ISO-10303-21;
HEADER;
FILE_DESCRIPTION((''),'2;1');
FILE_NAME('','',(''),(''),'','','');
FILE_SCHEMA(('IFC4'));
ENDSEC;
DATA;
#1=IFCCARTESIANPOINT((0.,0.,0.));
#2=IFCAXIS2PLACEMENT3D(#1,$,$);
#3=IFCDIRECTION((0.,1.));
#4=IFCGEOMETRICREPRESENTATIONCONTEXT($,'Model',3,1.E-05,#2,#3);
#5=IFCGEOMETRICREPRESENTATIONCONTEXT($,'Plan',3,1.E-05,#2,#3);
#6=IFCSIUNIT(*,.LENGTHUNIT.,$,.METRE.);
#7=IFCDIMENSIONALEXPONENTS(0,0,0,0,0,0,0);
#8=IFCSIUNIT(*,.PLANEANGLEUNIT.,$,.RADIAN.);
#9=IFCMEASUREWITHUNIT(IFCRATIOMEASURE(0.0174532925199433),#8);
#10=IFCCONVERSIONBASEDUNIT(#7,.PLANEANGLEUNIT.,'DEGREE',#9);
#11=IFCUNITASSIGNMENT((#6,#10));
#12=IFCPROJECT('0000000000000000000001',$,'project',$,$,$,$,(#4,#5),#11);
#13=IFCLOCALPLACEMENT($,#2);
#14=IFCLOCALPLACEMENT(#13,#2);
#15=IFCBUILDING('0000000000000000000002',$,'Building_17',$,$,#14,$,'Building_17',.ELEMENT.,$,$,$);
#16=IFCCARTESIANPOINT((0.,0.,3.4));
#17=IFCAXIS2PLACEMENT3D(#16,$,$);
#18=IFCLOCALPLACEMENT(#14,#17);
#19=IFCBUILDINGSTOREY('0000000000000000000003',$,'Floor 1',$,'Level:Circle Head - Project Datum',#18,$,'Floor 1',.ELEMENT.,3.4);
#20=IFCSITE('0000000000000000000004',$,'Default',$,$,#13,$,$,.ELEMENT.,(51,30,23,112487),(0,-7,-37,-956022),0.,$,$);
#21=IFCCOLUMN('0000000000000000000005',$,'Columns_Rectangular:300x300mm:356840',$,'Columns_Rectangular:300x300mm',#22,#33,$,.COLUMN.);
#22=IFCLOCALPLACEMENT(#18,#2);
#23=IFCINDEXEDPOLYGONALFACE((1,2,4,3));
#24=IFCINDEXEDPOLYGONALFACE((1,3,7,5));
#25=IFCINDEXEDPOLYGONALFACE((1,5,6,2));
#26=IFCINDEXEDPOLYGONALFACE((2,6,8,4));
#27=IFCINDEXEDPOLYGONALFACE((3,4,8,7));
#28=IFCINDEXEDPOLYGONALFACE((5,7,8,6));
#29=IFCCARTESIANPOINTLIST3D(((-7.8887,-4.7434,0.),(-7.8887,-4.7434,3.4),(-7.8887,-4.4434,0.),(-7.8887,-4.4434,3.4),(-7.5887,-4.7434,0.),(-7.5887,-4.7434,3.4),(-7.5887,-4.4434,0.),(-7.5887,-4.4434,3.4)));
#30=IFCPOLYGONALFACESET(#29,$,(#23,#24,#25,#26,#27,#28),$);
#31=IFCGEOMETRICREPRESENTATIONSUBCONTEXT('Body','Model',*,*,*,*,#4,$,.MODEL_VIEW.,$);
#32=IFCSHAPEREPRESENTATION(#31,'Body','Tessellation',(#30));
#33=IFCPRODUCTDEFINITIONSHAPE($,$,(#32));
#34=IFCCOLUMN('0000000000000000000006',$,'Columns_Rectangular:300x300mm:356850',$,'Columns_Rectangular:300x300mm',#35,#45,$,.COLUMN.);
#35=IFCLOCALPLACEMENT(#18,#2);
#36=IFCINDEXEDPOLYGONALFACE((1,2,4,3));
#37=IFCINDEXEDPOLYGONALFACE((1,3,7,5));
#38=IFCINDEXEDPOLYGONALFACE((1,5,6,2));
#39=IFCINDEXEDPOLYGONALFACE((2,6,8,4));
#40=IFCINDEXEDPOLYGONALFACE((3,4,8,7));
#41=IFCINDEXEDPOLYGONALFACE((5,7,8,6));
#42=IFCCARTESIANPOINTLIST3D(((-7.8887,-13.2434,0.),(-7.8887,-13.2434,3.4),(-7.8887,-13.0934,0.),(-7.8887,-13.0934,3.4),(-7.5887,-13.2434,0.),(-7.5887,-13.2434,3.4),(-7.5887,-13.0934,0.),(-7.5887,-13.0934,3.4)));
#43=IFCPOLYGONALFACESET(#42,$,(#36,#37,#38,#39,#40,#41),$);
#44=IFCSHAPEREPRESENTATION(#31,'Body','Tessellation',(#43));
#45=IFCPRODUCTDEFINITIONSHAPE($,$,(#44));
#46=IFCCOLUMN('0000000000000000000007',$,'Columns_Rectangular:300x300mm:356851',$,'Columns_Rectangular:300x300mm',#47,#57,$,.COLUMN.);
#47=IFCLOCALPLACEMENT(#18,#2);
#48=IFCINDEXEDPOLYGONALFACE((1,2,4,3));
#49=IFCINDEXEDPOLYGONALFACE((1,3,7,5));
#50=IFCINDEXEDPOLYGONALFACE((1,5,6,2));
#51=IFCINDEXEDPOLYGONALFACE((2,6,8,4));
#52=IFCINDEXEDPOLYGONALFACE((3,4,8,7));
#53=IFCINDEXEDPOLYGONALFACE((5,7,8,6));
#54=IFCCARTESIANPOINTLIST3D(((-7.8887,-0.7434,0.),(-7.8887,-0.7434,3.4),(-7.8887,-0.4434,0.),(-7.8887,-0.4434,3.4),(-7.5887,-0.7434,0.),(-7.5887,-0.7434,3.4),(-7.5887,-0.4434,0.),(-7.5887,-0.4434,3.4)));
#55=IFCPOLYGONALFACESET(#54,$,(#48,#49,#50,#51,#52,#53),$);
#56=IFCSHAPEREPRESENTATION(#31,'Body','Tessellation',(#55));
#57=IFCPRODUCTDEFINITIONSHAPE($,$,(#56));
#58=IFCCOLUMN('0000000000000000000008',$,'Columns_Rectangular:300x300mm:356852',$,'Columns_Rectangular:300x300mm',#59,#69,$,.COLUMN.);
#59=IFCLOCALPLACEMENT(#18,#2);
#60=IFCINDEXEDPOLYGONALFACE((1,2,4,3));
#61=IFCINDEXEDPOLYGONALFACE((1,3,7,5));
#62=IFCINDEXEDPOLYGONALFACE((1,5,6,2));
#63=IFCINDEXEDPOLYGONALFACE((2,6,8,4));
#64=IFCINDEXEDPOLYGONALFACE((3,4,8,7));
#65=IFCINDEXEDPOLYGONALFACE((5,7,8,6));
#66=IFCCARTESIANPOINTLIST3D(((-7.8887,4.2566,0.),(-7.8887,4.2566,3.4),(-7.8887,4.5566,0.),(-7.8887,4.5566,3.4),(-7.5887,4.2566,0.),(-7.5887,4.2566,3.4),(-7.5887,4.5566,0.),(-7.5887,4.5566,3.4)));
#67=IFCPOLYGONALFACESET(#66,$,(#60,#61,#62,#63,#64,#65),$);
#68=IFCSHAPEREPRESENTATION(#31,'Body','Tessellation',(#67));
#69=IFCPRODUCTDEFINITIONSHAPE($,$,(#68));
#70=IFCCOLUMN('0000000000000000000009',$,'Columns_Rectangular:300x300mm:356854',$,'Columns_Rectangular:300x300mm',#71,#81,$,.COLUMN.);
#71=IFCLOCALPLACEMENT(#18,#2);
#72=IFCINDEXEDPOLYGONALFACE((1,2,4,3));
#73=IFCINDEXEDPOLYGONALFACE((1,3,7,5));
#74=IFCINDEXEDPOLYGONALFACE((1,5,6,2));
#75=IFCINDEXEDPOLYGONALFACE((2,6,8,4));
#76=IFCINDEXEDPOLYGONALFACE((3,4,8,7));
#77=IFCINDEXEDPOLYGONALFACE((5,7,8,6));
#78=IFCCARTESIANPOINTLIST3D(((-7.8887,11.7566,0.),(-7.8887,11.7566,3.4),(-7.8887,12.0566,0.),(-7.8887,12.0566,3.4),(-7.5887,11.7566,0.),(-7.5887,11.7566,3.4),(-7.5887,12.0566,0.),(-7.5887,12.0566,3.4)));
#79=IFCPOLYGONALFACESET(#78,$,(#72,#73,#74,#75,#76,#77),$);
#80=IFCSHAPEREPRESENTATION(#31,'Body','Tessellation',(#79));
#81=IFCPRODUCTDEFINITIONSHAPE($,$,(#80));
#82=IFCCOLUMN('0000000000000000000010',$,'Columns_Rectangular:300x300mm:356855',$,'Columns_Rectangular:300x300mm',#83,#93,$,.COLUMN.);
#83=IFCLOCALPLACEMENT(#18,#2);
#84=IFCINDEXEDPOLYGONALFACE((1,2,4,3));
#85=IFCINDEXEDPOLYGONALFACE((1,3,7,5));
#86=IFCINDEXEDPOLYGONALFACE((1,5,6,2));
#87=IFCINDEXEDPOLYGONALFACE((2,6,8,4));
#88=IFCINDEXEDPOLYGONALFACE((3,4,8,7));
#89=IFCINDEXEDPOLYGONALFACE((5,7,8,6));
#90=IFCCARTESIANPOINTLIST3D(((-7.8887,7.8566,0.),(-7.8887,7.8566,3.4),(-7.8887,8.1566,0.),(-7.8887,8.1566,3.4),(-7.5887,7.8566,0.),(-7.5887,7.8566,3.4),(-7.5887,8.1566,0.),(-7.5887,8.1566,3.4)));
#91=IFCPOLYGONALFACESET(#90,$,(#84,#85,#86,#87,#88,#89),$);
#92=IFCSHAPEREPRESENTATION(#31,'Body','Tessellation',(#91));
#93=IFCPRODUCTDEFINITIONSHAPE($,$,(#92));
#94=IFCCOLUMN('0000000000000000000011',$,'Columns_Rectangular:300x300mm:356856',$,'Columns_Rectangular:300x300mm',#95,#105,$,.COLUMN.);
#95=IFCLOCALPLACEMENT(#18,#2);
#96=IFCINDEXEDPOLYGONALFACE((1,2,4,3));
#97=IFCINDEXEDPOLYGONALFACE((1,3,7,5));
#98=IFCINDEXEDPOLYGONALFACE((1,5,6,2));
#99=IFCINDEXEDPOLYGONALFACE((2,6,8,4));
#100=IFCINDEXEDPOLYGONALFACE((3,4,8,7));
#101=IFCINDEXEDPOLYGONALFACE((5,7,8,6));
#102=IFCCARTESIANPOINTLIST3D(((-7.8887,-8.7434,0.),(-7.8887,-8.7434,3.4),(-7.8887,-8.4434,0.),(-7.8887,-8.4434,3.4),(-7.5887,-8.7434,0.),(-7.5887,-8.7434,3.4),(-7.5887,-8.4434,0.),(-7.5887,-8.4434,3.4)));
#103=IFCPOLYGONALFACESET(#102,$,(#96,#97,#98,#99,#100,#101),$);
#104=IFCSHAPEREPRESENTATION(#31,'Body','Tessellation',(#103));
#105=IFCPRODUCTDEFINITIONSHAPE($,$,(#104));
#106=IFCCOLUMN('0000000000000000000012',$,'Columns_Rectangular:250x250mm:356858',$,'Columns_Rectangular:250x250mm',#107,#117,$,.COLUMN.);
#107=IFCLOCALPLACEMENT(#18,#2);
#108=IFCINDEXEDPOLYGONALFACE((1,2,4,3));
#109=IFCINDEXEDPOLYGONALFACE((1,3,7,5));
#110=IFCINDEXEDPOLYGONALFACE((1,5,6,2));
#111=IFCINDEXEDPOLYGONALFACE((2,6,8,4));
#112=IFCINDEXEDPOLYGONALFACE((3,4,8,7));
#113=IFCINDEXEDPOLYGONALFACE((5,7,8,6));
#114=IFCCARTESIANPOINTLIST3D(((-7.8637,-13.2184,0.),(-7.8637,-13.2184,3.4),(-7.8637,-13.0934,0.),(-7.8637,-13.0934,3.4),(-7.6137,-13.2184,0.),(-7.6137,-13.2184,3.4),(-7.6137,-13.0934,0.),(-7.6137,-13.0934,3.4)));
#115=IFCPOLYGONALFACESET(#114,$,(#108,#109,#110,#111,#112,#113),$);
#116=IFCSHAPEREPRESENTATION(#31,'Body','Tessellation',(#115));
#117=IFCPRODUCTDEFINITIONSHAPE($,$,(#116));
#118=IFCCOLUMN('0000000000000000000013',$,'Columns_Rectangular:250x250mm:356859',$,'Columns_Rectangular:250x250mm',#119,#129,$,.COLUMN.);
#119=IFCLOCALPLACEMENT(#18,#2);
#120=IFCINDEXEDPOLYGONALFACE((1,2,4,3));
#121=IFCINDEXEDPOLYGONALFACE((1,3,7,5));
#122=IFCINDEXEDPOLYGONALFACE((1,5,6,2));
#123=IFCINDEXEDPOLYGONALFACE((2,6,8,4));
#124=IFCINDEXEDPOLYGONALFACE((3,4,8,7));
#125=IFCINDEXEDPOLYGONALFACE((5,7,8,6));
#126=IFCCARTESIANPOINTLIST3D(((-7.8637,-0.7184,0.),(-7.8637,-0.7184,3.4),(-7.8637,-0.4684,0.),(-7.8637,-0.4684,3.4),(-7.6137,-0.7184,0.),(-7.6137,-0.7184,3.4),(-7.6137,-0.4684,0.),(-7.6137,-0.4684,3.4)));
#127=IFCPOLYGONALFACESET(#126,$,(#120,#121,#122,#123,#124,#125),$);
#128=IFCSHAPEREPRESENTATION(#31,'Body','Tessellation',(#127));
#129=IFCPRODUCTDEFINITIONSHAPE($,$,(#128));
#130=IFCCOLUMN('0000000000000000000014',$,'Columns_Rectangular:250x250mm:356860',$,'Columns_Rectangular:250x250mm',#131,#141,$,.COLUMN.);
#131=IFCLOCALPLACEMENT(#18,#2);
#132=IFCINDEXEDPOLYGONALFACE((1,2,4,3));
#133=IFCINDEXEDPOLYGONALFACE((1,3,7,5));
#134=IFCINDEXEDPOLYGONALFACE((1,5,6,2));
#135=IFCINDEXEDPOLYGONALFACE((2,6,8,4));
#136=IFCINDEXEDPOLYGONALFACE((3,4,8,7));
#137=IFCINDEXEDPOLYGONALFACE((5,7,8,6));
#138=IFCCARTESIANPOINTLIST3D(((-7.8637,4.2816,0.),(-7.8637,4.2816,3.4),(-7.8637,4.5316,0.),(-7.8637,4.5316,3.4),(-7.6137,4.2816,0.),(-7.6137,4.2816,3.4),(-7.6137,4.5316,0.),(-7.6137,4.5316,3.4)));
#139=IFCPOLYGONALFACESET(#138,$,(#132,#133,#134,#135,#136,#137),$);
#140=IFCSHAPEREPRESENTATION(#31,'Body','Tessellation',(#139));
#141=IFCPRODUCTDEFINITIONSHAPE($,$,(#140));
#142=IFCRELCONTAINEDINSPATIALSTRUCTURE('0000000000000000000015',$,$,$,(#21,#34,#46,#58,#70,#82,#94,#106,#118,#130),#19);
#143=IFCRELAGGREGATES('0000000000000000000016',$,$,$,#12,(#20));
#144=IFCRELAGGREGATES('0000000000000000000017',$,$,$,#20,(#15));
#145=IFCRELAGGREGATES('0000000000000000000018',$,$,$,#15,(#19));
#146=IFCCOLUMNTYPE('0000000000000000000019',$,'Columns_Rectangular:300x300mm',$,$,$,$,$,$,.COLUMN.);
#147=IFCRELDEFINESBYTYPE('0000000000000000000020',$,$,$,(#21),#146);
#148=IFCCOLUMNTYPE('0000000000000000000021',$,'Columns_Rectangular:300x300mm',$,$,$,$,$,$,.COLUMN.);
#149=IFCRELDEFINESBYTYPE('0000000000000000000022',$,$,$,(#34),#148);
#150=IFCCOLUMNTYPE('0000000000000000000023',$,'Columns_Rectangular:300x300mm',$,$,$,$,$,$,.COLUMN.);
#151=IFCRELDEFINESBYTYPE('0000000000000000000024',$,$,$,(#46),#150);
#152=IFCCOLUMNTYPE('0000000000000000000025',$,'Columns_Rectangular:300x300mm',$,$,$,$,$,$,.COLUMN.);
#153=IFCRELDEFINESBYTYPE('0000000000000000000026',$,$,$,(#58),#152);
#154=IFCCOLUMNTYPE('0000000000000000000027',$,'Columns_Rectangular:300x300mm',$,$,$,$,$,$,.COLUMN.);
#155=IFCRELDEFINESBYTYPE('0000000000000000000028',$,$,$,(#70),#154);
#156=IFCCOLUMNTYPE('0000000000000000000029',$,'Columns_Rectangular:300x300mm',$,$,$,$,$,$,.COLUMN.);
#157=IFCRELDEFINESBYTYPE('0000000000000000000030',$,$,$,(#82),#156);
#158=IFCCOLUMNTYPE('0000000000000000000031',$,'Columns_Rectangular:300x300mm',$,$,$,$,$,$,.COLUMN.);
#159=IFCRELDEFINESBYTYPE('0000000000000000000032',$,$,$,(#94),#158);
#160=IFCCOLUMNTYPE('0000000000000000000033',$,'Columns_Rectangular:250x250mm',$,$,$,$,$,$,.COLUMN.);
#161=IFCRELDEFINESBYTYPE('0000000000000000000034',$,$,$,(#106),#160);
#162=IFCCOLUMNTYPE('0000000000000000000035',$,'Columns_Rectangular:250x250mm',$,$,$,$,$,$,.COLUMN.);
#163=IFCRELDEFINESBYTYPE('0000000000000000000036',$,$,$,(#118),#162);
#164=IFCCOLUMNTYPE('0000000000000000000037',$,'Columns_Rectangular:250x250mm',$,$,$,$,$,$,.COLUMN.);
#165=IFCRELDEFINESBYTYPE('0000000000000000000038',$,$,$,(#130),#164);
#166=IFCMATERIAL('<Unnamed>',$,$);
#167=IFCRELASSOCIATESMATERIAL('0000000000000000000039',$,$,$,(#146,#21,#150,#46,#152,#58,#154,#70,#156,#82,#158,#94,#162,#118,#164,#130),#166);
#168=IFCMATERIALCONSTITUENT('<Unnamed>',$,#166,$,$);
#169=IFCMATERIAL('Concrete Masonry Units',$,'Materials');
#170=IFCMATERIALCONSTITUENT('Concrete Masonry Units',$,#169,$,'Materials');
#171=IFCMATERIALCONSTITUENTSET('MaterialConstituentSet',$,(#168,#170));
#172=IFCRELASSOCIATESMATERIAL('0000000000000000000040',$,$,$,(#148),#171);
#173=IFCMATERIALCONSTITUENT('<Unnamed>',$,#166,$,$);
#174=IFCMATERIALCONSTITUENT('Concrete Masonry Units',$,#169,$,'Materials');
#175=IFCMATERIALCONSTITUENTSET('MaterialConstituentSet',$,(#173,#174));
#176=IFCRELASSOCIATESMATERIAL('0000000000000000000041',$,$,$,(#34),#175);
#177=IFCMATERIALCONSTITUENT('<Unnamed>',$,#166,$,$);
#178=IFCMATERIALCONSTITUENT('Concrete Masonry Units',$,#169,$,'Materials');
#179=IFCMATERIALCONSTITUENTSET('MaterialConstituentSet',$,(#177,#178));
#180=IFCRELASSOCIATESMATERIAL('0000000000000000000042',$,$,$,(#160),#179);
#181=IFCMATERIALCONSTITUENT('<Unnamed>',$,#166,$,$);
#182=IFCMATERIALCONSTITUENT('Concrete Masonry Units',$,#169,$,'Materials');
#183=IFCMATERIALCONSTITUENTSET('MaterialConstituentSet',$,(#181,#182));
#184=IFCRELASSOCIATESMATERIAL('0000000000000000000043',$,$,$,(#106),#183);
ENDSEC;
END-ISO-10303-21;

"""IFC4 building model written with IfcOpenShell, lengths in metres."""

from ifc_helpers import new_model, entity, si_unit, converted_unit, direction, frame, origin, place, context, subcontext, project, spatial, indexed_curve, outline, extrude, source, transform, mapped, material, constituent, constituent_set, type_object, type_shapes, element, save


model = new_model("IFC4")

# Units and contexts
model_context = context("Model", 3, precision=1e-05, world=origin(), true_north=direction((0.0, 1.0)))
plan_context = context("Plan", 3, precision=1e-05, world=origin(), true_north=direction((0.0, 1.0)))
body_context = subcontext(model_context, "Body", "Model", "MODEL_VIEW")
ifc_project = project(units=[si_unit("LENGTHUNIT", "METRE"), converted_unit("PLANEANGLEUNIT", "DEGREE", entity("IfcRatioMeasure", 0.0174532925199433), si_unit("PLANEANGLEUNIT", "RADIAN"), dimensions=[0, 0, 0, 0, 0, 0, 0])], contexts=[model_context, plan_context])

# Site, building, storey
site_placement = place(None, origin())
site = spatial("IfcSite", under=ifc_project, at=site_placement, Name="Default", CompositionType="ELEMENT", RefLatitude=(51, 30, 23, 112487), RefLongitude=(0, -7, -37, -956022), RefElevation=0.0)
building_placement = place(site_placement, origin())
building = spatial("IfcBuilding", under=site, at=building_placement, Name="Building_17", LongName="Building_17", CompositionType="ELEMENT")
storey_placement = place(building_placement, frame((0.0, 0.0, 3.4)))
storey = spatial("IfcBuildingStorey", under=building, at=storey_placement, Name="Floor 1", ObjectType="Level:Circle Head - Project Datum", LongName="Floor 1", CompositionType="ELEMENT", Elevation=3.4)

# Columns
ifc_material_1 = material(Name="<Unnamed>")
column_type_1 = type_object("IfcColumnType", Name="Columns_Rectangular:300x300mm", PredefinedType="COLUMN", material=ifc_material_1)
shared_shape_1 = source(origin(), body_context, "Body", "SweptSolid", [
    extrude(outline(indexed_curve([(-0.15, -0.15), (0.15, -0.15), (0.15, 0.15), (-0.15, 0.15), (-0.15, -0.15)], self_intersect=False)), frame((-7.7387, -4.5934, 3.4), z_axis=(0.0, 0.0, 1.0), x_axis=(0.0, -1.0, 0.0)), (0.0, 0.0, 1.0), 3.4),
])
type_shapes(column_type_1, [shared_shape_1])
column_1_placement = place(storey_placement, frame((0.0, 0.0, -3.4)))
element("IfcColumn", 1, at=column_1_placement, inside=storey, type_object=column_type_1, material=ifc_material_1, Name="Columns_Rectangular:300x300mm:356840", ObjectType="Columns_Rectangular:300x300mm", PredefinedType="COLUMN", context=body_context, shape_type="MappedRepresentation", body=[
    mapped(shared_shape_1, transform((0.0, 0.0, 0.0), scale=1.0)),
])
ifc_constituent_1 = constituent(ifc_material_1, Name="<Unnamed>")
ifc_material_2 = material(Name="Concrete Masonry Units", Category="Materials")
ifc_constituent_2 = constituent(ifc_material_2, Name="Concrete Masonry Units", Category="Materials")
ifc_constituent_set_1 = constituent_set(constituents=[ifc_constituent_1, ifc_constituent_2], Name="MaterialConstituentSet")
ifc_constituent_3 = constituent(ifc_material_1, Name="<Unnamed>")
ifc_constituent_4 = constituent(ifc_material_2, Name="Concrete Masonry Units", Category="Materials")
ifc_constituent_set_2 = constituent_set(constituents=[ifc_constituent_3, ifc_constituent_4], Name="MaterialConstituentSet")
column_type_2 = type_object("IfcColumnType", Name="Columns_Rectangular:300x300mm", PredefinedType="COLUMN", material=ifc_constituent_set_2)
shared_shape_2 = source(origin(), body_context, "Body", "SweptSolid", [
    extrude(outline(indexed_curve([(-0.075, -0.15), (0.075, -0.15), (0.075, 0.15), (-0.075, 0.15), (-0.075, -0.15)], self_intersect=False)), frame((-7.7387, -13.1684, 3.4), z_axis=(0.0, 0.0, 1.0), x_axis=(0.0, -1.0, 0.0)), (0.0, 0.0, 1.0), 3.4),
])
type_shapes(column_type_2, [shared_shape_2])
column_2_placement = place(storey_placement, frame((0.0, 0.0, -3.4)))
element("IfcColumn", 2, at=column_2_placement, inside=storey, type_object=column_type_2, material=ifc_constituent_set_1, Name="Columns_Rectangular:300x300mm:356850", ObjectType="Columns_Rectangular:300x300mm", PredefinedType="COLUMN", context=body_context, shape_type="MappedRepresentation", body=[
    mapped(shared_shape_2, transform((0.0, 0.0, 0.0), scale=1.0)),
])
column_type_3 = type_object("IfcColumnType", Name="Columns_Rectangular:300x300mm", PredefinedType="COLUMN", material=ifc_material_1)
shared_shape_3 = source(origin(), body_context, "Body", "SweptSolid", [
    extrude(outline(indexed_curve([(-0.15, -0.15), (0.15, -0.15), (0.15, 0.15), (-0.15, 0.15), (-0.15, -0.15)], self_intersect=False)), frame((-7.7387, -0.5934, 3.4), z_axis=(0.0, 0.0, 1.0), x_axis=(0.0, -1.0, 0.0)), (0.0, 0.0, 1.0), 3.4),
])
type_shapes(column_type_3, [shared_shape_3])
column_3_placement = place(storey_placement, frame((0.0, 0.0, -3.4)))
element("IfcColumn", 3, at=column_3_placement, inside=storey, type_object=column_type_3, material=ifc_material_1, Name="Columns_Rectangular:300x300mm:356851", ObjectType="Columns_Rectangular:300x300mm", PredefinedType="COLUMN", context=body_context, shape_type="MappedRepresentation", body=[
    mapped(shared_shape_3, transform((0.0, 0.0, 0.0), scale=1.0)),
])
column_type_4 = type_object("IfcColumnType", Name="Columns_Rectangular:300x300mm", PredefinedType="COLUMN", material=ifc_material_1)
shared_shape_4 = source(origin(), body_context, "Body", "SweptSolid", [
    extrude(outline(indexed_curve([(-0.15, -0.15), (0.15, -0.15), (0.15, 0.15), (-0.15, 0.15), (-0.15, -0.15)], self_intersect=False)), frame((-7.7387, 4.4066, 3.4), z_axis=(0.0, 0.0, 1.0), x_axis=(0.0, -1.0, 0.0)), (0.0, 0.0, 1.0), 3.4),
])
type_shapes(column_type_4, [shared_shape_4])
column_4_placement = place(storey_placement, frame((0.0, 0.0, -3.4)))
element("IfcColumn", 4, at=column_4_placement, inside=storey, type_object=column_type_4, material=ifc_material_1, Name="Columns_Rectangular:300x300mm:356852", ObjectType="Columns_Rectangular:300x300mm", PredefinedType="COLUMN", context=body_context, shape_type="MappedRepresentation", body=[
    mapped(shared_shape_4, transform((0.0, 0.0, 0.0), scale=1.0)),
])
column_type_5 = type_object("IfcColumnType", Name="Columns_Rectangular:300x300mm", PredefinedType="COLUMN", material=ifc_material_1)
shared_shape_5 = source(origin(), body_context, "Body", "SweptSolid", [
    extrude(outline(indexed_curve([(-0.15, -0.15), (0.15, -0.15), (0.15, 0.15), (-0.15, 0.15), (-0.15, -0.15)], self_intersect=False)), frame((-7.7387, 11.9066, 3.4), z_axis=(0.0, 0.0, 1.0), x_axis=(0.0, -1.0, 0.0)), (0.0, 0.0, 1.0), 3.4),
])
type_shapes(column_type_5, [shared_shape_5])
column_5_placement = place(storey_placement, frame((0.0, 0.0, -3.4)))
element("IfcColumn", 5, at=column_5_placement, inside=storey, type_object=column_type_5, material=ifc_material_1, Name="Columns_Rectangular:300x300mm:356854", ObjectType="Columns_Rectangular:300x300mm", PredefinedType="COLUMN", context=body_context, shape_type="MappedRepresentation", body=[
    mapped(shared_shape_5, transform((0.0, 0.0, 0.0), scale=1.0)),
])
column_type_6 = type_object("IfcColumnType", Name="Columns_Rectangular:300x300mm", PredefinedType="COLUMN", material=ifc_material_1)
shared_shape_6 = source(origin(), body_context, "Body", "SweptSolid", [
    extrude(outline(indexed_curve([(-0.15, -0.15), (0.15, -0.15), (0.15, 0.15), (-0.15, 0.15), (-0.15, -0.15)], self_intersect=False)), frame((-7.7387, 8.0066, 3.4), z_axis=(0.0, 0.0, 1.0), x_axis=(0.0, -1.0, 0.0)), (0.0, 0.0, 1.0), 3.4),
])
type_shapes(column_type_6, [shared_shape_6])
column_6_placement = place(storey_placement, frame((0.0, 0.0, -3.4)))
element("IfcColumn", 6, at=column_6_placement, inside=storey, type_object=column_type_6, material=ifc_material_1, Name="Columns_Rectangular:300x300mm:356855", ObjectType="Columns_Rectangular:300x300mm", PredefinedType="COLUMN", context=body_context, shape_type="MappedRepresentation", body=[
    mapped(shared_shape_6, transform((0.0, 0.0, 0.0), scale=1.0)),
])
column_type_7 = type_object("IfcColumnType", Name="Columns_Rectangular:300x300mm", PredefinedType="COLUMN", material=ifc_material_1)
shared_shape_7 = source(origin(), body_context, "Body", "SweptSolid", [
    extrude(outline(indexed_curve([(-0.15, -0.15), (0.15, -0.15), (0.15, 0.15), (-0.15, 0.15), (-0.15, -0.15)], self_intersect=False)), frame((-7.7387, -8.5934, 3.4), z_axis=(0.0, 0.0, 1.0), x_axis=(0.0, -1.0, 0.0)), (0.0, 0.0, 1.0), 3.4),
])
type_shapes(column_type_7, [shared_shape_7])
column_7_placement = place(storey_placement, frame((0.0, 0.0, -3.4)))
element("IfcColumn", 7, at=column_7_placement, inside=storey, type_object=column_type_7, material=ifc_material_1, Name="Columns_Rectangular:300x300mm:356856", ObjectType="Columns_Rectangular:300x300mm", PredefinedType="COLUMN", context=body_context, shape_type="MappedRepresentation", body=[
    mapped(shared_shape_7, transform((0.0, 0.0, 0.0), scale=1.0)),
])
ifc_constituent_5 = constituent(ifc_material_1, Name="<Unnamed>")
ifc_constituent_6 = constituent(ifc_material_2, Name="Concrete Masonry Units", Category="Materials")
ifc_constituent_set_3 = constituent_set(constituents=[ifc_constituent_5, ifc_constituent_6], Name="MaterialConstituentSet")
ifc_constituent_7 = constituent(ifc_material_1, Name="<Unnamed>")
ifc_constituent_8 = constituent(ifc_material_2, Name="Concrete Masonry Units", Category="Materials")
ifc_constituent_set_4 = constituent_set(constituents=[ifc_constituent_7, ifc_constituent_8], Name="MaterialConstituentSet")
column_type_8 = type_object("IfcColumnType", Name="Columns_Rectangular:250x250mm", PredefinedType="COLUMN", material=ifc_constituent_set_4)
shared_shape_8 = source(origin(), body_context, "Body", "SweptSolid", [
    extrude(outline(indexed_curve([(-0.0625, -0.125), (0.0625, -0.125), (0.0625, 0.125), (-0.0625, 0.125), (-0.0625, -0.125)], self_intersect=False)), frame((-7.7387, -13.1559, 3.4), z_axis=(0.0, 0.0, 1.0), x_axis=(0.0, -1.0, 0.0)), (0.0, 0.0, 1.0), 3.4),
])
type_shapes(column_type_8, [shared_shape_8])
column_8_placement = place(storey_placement, frame((0.0, 0.0, -3.4)))
element("IfcColumn", 8, at=column_8_placement, inside=storey, type_object=column_type_8, material=ifc_constituent_set_3, Name="Columns_Rectangular:250x250mm:356858", ObjectType="Columns_Rectangular:250x250mm", PredefinedType="COLUMN", context=body_context, shape_type="MappedRepresentation", body=[
    mapped(shared_shape_8, transform((0.0, 0.0, 0.0), scale=1.0)),
])
column_type_9 = type_object("IfcColumnType", Name="Columns_Rectangular:250x250mm", PredefinedType="COLUMN", material=ifc_material_1)
shared_shape_9 = source(origin(), body_context, "Body", "SweptSolid", [
    extrude(outline(indexed_curve([(-0.125, -0.125), (0.125, -0.125), (0.125, 0.125), (-0.125, 0.125), (-0.125, -0.125)], self_intersect=False)), frame((-7.7387, -0.5934, 3.4), z_axis=(0.0, 0.0, 1.0), x_axis=(0.0, -1.0, 0.0)), (0.0, 0.0, 1.0), 3.4),
])
type_shapes(column_type_9, [shared_shape_9])
column_9_placement = place(storey_placement, frame((0.0, 0.0, -3.4)))
element("IfcColumn", 9, at=column_9_placement, inside=storey, type_object=column_type_9, material=ifc_material_1, Name="Columns_Rectangular:250x250mm:356859", ObjectType="Columns_Rectangular:250x250mm", PredefinedType="COLUMN", context=body_context, shape_type="MappedRepresentation", body=[
    mapped(shared_shape_9, transform((0.0, 0.0, 0.0), scale=1.0)),
])
column_type_10 = type_object("IfcColumnType", Name="Columns_Rectangular:250x250mm", PredefinedType="COLUMN", material=ifc_material_1)
shared_shape_10 = source(origin(), body_context, "Body", "SweptSolid", [
    extrude(outline(indexed_curve([(-0.125, -0.125), (0.125, -0.125), (0.125, 0.125), (-0.125, 0.125), (-0.125, -0.125)], self_intersect=False)), frame((-7.7387, 4.4066, 3.4), z_axis=(0.0, 0.0, 1.0), x_axis=(0.0, -1.0, 0.0)), (0.0, 0.0, 1.0), 3.4),
])
type_shapes(column_type_10, [shared_shape_10])
column_10_placement = place(storey_placement, frame((0.0, 0.0, -3.4)))
element("IfcColumn", 10, at=column_10_placement, inside=storey, type_object=column_type_10, material=ifc_material_1, Name="Columns_Rectangular:250x250mm:356860", ObjectType="Columns_Rectangular:250x250mm", PredefinedType="COLUMN", context=body_context, shape_type="MappedRepresentation", body=[
    mapped(shared_shape_10, transform((0.0, 0.0, 0.0), scale=1.0)),
])

save(model, "model.ifc")
